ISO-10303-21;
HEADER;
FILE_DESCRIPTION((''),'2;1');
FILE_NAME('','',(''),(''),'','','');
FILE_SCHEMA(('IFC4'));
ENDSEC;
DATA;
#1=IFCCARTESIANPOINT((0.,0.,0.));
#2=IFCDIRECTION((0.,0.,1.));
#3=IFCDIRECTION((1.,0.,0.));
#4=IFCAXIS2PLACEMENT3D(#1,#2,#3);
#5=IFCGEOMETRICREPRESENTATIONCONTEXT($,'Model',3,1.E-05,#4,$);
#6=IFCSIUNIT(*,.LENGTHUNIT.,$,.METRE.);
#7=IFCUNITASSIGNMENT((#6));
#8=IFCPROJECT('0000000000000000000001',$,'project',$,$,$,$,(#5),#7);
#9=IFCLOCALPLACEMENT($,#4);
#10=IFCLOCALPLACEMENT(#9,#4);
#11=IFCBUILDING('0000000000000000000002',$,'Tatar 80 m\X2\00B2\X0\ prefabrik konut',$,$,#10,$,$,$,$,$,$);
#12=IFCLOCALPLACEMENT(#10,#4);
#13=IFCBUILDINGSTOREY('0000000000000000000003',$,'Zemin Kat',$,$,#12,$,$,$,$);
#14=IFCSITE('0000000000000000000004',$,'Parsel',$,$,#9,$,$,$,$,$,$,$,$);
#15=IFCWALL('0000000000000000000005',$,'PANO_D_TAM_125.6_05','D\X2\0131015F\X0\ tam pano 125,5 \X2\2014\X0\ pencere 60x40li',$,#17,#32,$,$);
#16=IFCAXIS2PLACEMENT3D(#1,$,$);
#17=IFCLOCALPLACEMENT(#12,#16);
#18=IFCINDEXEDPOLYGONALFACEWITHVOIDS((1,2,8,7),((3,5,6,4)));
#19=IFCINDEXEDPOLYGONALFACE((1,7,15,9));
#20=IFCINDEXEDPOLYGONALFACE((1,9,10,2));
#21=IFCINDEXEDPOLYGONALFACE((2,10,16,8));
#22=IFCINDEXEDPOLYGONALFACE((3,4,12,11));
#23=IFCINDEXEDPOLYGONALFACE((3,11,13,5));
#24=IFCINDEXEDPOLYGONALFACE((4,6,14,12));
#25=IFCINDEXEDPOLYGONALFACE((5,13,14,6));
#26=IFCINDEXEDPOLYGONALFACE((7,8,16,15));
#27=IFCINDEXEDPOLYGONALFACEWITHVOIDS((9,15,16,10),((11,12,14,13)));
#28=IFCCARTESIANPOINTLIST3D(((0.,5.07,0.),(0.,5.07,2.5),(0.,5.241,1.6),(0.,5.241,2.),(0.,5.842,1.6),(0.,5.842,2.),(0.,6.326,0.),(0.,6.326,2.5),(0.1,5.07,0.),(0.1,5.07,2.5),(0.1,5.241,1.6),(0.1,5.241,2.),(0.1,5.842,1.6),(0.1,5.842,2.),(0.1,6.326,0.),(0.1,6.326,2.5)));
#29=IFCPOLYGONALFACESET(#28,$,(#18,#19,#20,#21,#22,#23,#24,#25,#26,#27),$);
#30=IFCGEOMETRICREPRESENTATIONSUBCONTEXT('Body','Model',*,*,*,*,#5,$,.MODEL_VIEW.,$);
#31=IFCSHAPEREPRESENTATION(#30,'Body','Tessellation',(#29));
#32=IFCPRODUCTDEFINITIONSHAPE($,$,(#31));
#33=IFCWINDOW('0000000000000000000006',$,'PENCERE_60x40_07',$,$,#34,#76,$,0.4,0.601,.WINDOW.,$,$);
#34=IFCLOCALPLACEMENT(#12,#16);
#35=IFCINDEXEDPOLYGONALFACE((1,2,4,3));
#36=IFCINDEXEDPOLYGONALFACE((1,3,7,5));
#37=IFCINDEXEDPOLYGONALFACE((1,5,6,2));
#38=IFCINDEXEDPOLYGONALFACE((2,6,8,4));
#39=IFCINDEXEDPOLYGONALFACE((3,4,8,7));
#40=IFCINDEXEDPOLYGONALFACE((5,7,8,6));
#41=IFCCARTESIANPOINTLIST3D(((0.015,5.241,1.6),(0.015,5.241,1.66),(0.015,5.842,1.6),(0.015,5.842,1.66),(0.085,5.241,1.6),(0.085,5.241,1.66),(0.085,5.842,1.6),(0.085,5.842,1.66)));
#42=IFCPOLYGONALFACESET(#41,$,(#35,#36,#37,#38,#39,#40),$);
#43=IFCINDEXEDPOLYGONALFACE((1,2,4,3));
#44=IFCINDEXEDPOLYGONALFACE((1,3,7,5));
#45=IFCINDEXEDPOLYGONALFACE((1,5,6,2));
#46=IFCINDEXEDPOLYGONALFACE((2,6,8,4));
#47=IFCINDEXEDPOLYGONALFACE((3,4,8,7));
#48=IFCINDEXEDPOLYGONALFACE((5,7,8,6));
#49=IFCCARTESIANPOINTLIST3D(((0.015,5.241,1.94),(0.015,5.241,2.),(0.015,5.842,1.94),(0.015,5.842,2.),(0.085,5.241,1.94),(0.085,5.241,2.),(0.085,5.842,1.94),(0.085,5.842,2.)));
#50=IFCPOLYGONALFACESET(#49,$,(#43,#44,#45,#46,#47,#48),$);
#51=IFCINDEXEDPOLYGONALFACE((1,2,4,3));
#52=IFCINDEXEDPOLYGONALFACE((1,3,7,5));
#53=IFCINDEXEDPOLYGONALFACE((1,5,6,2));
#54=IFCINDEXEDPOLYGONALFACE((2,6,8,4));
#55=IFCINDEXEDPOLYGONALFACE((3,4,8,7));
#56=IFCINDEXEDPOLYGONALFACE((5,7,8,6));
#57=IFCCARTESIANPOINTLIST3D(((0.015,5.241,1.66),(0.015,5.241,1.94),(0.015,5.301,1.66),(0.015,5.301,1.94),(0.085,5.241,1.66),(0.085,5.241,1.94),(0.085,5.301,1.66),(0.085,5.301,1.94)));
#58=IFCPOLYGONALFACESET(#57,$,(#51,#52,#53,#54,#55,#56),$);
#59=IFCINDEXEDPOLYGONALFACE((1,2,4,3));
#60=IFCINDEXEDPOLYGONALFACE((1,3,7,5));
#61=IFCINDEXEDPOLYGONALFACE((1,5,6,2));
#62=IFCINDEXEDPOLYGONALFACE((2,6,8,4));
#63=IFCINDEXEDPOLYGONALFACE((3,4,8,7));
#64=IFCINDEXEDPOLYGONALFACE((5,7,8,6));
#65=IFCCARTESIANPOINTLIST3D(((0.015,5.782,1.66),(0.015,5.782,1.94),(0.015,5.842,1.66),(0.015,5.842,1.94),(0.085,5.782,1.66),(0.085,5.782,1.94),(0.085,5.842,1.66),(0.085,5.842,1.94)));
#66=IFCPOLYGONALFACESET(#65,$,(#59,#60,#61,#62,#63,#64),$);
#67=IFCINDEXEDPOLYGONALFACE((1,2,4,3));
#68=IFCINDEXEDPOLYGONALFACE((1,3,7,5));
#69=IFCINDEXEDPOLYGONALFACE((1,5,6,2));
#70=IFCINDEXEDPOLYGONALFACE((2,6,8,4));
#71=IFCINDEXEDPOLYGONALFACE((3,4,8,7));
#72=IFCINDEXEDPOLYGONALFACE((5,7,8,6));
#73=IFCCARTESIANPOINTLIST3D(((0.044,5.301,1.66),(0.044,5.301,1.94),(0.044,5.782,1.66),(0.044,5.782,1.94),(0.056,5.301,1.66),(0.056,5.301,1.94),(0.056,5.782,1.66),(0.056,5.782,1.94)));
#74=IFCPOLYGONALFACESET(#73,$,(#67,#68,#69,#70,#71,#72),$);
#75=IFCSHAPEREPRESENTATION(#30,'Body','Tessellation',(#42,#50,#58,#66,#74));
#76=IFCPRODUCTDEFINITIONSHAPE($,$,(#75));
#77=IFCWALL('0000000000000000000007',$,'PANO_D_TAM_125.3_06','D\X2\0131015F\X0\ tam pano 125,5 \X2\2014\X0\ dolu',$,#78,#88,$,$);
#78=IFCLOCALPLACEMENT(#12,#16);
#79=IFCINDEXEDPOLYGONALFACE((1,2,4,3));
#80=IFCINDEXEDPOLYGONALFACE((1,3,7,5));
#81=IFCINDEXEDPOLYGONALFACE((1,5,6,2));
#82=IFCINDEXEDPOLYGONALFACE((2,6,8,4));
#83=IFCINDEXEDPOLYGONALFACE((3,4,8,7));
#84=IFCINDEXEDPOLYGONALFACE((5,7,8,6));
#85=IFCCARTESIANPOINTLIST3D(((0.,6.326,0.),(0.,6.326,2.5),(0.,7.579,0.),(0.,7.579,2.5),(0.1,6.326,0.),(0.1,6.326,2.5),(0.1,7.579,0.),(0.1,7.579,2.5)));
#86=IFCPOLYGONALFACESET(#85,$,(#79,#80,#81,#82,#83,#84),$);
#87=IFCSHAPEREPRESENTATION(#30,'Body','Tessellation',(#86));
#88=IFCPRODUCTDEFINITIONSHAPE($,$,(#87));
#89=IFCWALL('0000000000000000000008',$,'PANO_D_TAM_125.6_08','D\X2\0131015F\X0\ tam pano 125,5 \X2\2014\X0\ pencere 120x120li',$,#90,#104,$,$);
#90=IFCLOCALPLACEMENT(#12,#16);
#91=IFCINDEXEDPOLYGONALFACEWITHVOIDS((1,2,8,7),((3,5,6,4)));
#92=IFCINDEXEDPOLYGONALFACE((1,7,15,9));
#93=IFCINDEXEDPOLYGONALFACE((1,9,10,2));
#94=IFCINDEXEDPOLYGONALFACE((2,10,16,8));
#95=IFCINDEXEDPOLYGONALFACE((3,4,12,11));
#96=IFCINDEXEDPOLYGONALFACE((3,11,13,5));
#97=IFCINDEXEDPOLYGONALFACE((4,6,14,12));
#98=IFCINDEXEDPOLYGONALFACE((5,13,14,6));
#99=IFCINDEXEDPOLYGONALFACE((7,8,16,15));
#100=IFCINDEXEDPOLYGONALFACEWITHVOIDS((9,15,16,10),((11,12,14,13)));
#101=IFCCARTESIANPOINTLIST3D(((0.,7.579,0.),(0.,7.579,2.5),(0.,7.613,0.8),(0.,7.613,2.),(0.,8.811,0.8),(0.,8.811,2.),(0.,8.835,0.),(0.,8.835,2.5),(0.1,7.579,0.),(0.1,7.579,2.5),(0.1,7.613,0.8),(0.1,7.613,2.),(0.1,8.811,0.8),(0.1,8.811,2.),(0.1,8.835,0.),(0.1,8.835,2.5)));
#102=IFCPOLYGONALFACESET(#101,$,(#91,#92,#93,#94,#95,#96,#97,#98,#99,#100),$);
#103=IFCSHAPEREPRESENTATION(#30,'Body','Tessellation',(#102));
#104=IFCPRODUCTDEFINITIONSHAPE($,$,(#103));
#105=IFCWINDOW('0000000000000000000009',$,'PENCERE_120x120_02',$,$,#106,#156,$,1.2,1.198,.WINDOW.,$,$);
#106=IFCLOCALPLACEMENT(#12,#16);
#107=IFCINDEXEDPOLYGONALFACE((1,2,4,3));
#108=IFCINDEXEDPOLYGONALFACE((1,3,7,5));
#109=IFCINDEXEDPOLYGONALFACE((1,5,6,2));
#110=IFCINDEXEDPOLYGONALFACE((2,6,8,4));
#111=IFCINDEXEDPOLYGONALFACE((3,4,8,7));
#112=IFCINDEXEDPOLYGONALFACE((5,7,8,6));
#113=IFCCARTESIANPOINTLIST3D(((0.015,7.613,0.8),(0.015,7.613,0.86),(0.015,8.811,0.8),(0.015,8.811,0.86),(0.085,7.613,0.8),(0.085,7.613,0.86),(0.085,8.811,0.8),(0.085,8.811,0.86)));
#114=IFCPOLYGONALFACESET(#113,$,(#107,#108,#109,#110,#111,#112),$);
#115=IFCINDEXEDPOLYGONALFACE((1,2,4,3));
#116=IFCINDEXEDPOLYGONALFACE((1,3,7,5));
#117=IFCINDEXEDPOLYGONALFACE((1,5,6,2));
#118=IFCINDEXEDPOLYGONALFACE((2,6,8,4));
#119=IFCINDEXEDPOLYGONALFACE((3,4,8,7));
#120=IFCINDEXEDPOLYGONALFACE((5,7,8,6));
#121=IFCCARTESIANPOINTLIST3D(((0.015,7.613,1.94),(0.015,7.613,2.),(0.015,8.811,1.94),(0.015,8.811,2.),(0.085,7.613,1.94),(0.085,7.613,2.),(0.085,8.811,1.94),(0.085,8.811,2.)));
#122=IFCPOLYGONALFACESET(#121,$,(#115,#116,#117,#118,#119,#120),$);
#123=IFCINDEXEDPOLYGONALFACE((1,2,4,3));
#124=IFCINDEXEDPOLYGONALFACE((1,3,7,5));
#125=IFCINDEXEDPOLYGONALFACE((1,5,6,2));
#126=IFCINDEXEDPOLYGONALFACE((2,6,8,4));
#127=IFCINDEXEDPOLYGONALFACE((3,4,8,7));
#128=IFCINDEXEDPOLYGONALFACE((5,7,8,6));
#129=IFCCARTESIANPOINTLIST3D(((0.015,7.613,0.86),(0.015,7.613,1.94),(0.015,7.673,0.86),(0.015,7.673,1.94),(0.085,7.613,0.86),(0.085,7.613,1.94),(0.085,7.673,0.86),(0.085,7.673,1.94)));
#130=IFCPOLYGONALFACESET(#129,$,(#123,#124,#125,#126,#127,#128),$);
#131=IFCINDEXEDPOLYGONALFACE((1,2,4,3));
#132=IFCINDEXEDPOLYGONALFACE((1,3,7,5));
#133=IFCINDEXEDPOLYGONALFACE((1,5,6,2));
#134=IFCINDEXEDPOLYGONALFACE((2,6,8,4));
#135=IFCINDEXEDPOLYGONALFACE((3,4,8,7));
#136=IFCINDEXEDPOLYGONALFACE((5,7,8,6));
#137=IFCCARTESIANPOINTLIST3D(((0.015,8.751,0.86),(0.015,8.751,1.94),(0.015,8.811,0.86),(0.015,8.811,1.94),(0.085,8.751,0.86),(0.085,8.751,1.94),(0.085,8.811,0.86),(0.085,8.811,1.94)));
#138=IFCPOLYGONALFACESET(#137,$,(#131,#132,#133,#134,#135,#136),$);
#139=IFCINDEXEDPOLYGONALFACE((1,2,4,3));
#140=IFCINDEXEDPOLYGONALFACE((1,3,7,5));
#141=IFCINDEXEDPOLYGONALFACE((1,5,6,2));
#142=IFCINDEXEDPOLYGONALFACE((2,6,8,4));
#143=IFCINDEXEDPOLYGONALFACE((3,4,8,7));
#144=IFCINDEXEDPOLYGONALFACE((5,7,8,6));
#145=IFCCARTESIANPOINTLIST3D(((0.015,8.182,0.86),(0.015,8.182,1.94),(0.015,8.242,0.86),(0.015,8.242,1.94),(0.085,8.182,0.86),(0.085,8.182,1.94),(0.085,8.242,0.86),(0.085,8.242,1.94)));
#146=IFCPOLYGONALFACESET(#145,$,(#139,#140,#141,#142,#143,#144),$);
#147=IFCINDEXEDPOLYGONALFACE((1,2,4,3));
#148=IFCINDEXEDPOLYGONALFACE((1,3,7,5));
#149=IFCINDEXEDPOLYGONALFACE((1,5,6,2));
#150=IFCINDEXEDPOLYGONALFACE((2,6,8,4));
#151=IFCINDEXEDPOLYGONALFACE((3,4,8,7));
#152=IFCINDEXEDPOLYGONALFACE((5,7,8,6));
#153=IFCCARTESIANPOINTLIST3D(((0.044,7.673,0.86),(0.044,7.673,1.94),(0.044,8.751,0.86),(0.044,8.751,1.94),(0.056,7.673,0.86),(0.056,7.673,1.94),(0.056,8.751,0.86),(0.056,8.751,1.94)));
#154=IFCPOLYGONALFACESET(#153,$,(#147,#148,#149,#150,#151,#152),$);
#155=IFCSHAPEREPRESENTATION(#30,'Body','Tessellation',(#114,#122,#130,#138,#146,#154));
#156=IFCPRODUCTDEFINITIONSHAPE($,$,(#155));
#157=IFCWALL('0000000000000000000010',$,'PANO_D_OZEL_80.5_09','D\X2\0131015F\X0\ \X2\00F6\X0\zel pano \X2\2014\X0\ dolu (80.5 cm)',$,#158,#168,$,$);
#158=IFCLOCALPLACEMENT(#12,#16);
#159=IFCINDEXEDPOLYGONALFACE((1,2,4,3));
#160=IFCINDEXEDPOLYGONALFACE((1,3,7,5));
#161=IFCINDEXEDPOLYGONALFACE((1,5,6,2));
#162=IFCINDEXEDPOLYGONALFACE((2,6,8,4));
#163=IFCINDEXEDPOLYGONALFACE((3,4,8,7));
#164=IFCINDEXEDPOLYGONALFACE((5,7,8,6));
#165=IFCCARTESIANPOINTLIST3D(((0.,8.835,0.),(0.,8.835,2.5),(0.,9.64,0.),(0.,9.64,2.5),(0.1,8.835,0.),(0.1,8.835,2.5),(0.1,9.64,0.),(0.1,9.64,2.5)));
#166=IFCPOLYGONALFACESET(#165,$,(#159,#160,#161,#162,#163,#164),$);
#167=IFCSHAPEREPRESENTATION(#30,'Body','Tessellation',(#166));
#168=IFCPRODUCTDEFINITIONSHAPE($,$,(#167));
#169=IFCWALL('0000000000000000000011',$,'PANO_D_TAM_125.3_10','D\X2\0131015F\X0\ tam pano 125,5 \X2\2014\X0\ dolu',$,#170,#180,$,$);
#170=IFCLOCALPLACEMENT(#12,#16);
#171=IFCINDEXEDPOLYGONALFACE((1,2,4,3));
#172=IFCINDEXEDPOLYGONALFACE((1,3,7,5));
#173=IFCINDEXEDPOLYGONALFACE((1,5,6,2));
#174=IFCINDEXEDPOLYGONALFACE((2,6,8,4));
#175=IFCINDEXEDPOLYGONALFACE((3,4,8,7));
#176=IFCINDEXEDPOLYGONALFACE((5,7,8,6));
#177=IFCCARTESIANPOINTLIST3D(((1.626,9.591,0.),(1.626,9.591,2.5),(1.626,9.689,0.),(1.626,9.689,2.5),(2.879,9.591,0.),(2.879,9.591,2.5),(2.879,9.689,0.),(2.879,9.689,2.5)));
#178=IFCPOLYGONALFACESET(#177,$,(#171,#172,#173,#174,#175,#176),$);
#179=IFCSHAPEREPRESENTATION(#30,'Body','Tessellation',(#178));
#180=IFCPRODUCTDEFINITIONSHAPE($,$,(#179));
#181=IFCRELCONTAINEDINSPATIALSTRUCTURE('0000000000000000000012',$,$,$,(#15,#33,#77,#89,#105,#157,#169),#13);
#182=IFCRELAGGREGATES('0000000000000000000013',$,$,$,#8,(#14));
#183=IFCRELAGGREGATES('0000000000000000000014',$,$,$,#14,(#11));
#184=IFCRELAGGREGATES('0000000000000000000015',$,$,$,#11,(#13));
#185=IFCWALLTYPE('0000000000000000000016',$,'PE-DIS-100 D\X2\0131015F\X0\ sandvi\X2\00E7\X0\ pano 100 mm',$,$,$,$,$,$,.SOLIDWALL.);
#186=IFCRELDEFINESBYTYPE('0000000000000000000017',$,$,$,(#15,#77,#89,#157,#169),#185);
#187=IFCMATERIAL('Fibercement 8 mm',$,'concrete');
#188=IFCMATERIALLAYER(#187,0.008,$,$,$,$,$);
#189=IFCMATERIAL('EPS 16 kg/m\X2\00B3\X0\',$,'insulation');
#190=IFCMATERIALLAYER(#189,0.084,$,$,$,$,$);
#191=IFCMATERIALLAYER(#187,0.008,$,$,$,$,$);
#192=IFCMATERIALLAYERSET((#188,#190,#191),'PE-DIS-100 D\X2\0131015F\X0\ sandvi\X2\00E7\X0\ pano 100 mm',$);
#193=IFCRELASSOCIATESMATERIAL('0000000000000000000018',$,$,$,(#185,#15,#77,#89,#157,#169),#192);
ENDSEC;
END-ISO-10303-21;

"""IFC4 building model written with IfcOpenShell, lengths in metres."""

from ifc_helpers import new_model, si_unit, frame, origin_with_axes, place, context, subcontext, project, spatial, line, indexed_curve, outline, extrude, material, layer, layer_set, layer_usage, type_object, element, fill, save


model = new_model("IFC4")

# Units and contexts
model_context = context("Model", 3, precision=1e-05, world=origin_with_axes())
body_context = subcontext(model_context, "Body", "Model", "MODEL_VIEW")
ifc_project = project(units=[si_unit("LENGTHUNIT", "METRE")], contexts=[model_context])

# Site, building, storey
site_placement = place(None, origin_with_axes())
site = spatial("IfcSite", under=ifc_project, at=site_placement, Name="Parsel")
building_placement = place(site_placement, origin_with_axes())
building = spatial("IfcBuilding", under=site, at=building_placement, Name="Tatar 80 m² prefabrik konut")
storey_placement = place(building_placement, origin_with_axes())
storey = spatial("IfcBuildingStorey", under=building, at=storey_placement, Name="Zemin Kat")

# Wall, opening, window
ifc_material_1 = material(Name="Fibercement 8 mm", Category="concrete")
ifc_layer_1 = layer(ifc_material_1, 0.008)
ifc_material_2 = material(Name="EPS 16 kg/m³", Category="insulation")
ifc_layer_2 = layer(ifc_material_2, 0.084)
ifc_layer_3 = layer(ifc_material_1, 0.008)
ifc_layer_set_1 = layer_set([ifc_layer_1, ifc_layer_2, ifc_layer_3], Name="PE-DIS-100 Dış sandviç pano 100 mm")
ifc_layer_usage_1 = layer_usage(ifc_layer_set_1, "AXIS2", "POSITIVE", 0.0)
wall_type_1 = type_object("IfcWallType", Name="PE-DIS-100 Dış sandviç pano 100 mm", PredefinedType="SOLIDWALL", material=ifc_layer_set_1)
wall_1_placement = place(storey_placement, frame((0.1, 5.07, 0.0), z_axis=(0.0, 0.0, 1.0), x_axis=(0.0, 1.0, 0.0)))
wall_1 = element("IfcWall", 1, at=wall_1_placement, inside=storey, type_object=wall_type_1, material=ifc_layer_usage_1, Name="PANO_D_TAM_125.6_05", Description="Dış tam pano 125,5 — pencere 60x40li", context=body_context, shape_type="SweptSolid", body=[
    extrude(outline(indexed_curve([(0.0, 0.0), (1.256, 0.0), (1.256, 0.1), (0.0, 0.1)], segments=[line(1, 2, 3, 4, 1)])), origin_with_axes(), (0.0, 0.0, 1.0), 2.5),
])
opening_1_placement = place(wall_1_placement, origin_with_axes())
opening_1 = element("IfcOpeningElement", 2, at=opening_1_placement, cuts=wall_1, PredefinedType="OPENING", context=body_context, shape_type="SweptSolid", body=[
    extrude(outline(indexed_curve([(0.0, 0.0), (0.601, 0.0), (0.601, 0.14), (0.0, 0.14)], segments=[line(1, 2, 3, 4, 1)])), frame((0.171, -0.02, 1.6), z_axis=(0.0, 0.0, 1.0), x_axis=(1.0, 0.0, 0.0)), (0.0, 0.0, 1.0), 0.4),
])
window_1_placement = place(storey_placement, frame((0.1, 5.07, 0.0), z_axis=(0.0, 0.0, 1.0), x_axis=(0.0, 1.0, 0.0)))
window_1 = element("IfcWindow", 3, at=window_1_placement, inside=storey, Name="PENCERE_60x40_07", OverallHeight=0.4, OverallWidth=0.601, PredefinedType="WINDOW", context=body_context, shape_type="SweptSolid", body=[
    extrude(outline(indexed_curve([(0.0, 0.0), (0.601, 0.0), (0.601, 0.07), (0.0, 0.07)], segments=[line(1, 2, 3, 4, 1)])), frame((0.171, 0.015, 1.6), z_axis=(0.0, 0.0, 1.0), x_axis=(1.0, 0.0, 0.0)), (0.0, 0.0, 1.0), 0.06),
    extrude(outline(indexed_curve([(0.0, 0.0), (0.601, 0.0), (0.601, 0.07), (0.0, 0.07)], segments=[line(1, 2, 3, 4, 1)])), frame((0.171, 0.015, 1.94), z_axis=(0.0, 0.0, 1.0), x_axis=(1.0, 0.0, 0.0)), (0.0, 0.0, 1.0), 0.06),
    extrude(outline(indexed_curve([(0.0, 0.0), (0.06, 0.0), (0.06, 0.07), (0.0, 0.07)], segments=[line(1, 2, 3, 4, 1)])), frame((0.171, 0.015, 1.66), z_axis=(0.0, 0.0, 1.0), x_axis=(1.0, 0.0, 0.0)), (0.0, 0.0, 1.0), 0.28),
    extrude(outline(indexed_curve([(0.0, 0.0), (0.06, 0.0), (0.06, 0.07), (0.0, 0.07)], segments=[line(1, 2, 3, 4, 1)])), frame((0.712, 0.015, 1.66), z_axis=(0.0, 0.0, 1.0), x_axis=(1.0, 0.0, 0.0)), (0.0, 0.0, 1.0), 0.28),
    extrude(outline(indexed_curve([(0.0, 0.0), (0.481, 0.0), (0.481, 0.012), (0.0, 0.012)], segments=[line(1, 2, 3, 4, 1)])), frame((0.231, 0.044, 1.66), z_axis=(0.0, 0.0, 1.0), x_axis=(1.0, 0.0, 0.0)), (0.0, 0.0, 1.0), 0.28),
])
fill(opening_1, window_1)

# Wall
ifc_layer_usage_2 = layer_usage(ifc_layer_set_1, "AXIS2", "POSITIVE", 0.0)
wall_2_placement = place(storey_placement, frame((0.1, 6.326, 0.0), z_axis=(0.0, 0.0, 1.0), x_axis=(0.0, 1.0, 0.0)))
element("IfcWall", 4, at=wall_2_placement, inside=storey, type_object=wall_type_1, material=ifc_layer_usage_2, Name="PANO_D_TAM_125.3_06", Description="Dış tam pano 125,5 — dolu", context=body_context, shape_type="SweptSolid", body=[
    extrude(outline(indexed_curve([(0.0, 0.0), (1.253, 0.0), (1.253, 0.1), (0.0, 0.1)], segments=[line(1, 2, 3, 4, 1)])), origin_with_axes(), (0.0, 0.0, 1.0), 2.5),
])

# Wall, opening, window
ifc_layer_usage_3 = layer_usage(ifc_layer_set_1, "AXIS2", "POSITIVE", 0.0)
wall_3_placement = place(storey_placement, frame((0.1, 7.579, 0.0), z_axis=(0.0, 0.0, 1.0), x_axis=(0.0, 1.0, 0.0)))
wall_3 = element("IfcWall", 5, at=wall_3_placement, inside=storey, type_object=wall_type_1, material=ifc_layer_usage_3, Name="PANO_D_TAM_125.6_08", Description="Dış tam pano 125,5 — pencere 120x120li", context=body_context, shape_type="SweptSolid", body=[
    extrude(outline(indexed_curve([(0.0, 0.0), (1.256, 0.0), (1.256, 0.1), (0.0, 0.1)], segments=[line(1, 2, 3, 4, 1)])), origin_with_axes(), (0.0, 0.0, 1.0), 2.5),
])
opening_2_placement = place(wall_3_placement, origin_with_axes())
opening_2 = element("IfcOpeningElement", 6, at=opening_2_placement, cuts=wall_3, PredefinedType="OPENING", context=body_context, shape_type="SweptSolid", body=[
    extrude(outline(indexed_curve([(0.0, 0.0), (1.198, 0.0), (1.198, 0.14), (0.0, 0.14)], segments=[line(1, 2, 3, 4, 1)])), frame((0.034, -0.02, 0.8), z_axis=(0.0, 0.0, 1.0), x_axis=(1.0, 0.0, 0.0)), (0.0, 0.0, 1.0), 1.2),
])
window_2_placement = place(storey_placement, frame((0.1, 7.579, 0.0), z_axis=(0.0, 0.0, 1.0), x_axis=(0.0, 1.0, 0.0)))
window_2 = element("IfcWindow", 7, at=window_2_placement, inside=storey, Name="PENCERE_120x120_02", OverallHeight=1.2, OverallWidth=1.198, PredefinedType="WINDOW", context=body_context, shape_type="SweptSolid", body=[
    extrude(outline(indexed_curve([(0.0, 0.0), (1.198, 0.0), (1.198, 0.07), (0.0, 0.07)], segments=[line(1, 2, 3, 4, 1)])), frame((0.034, 0.015, 0.8), z_axis=(0.0, 0.0, 1.0), x_axis=(1.0, 0.0, 0.0)), (0.0, 0.0, 1.0), 0.06),
    extrude(outline(indexed_curve([(0.0, 0.0), (1.198, 0.0), (1.198, 0.07), (0.0, 0.07)], segments=[line(1, 2, 3, 4, 1)])), frame((0.034, 0.015, 1.94), z_axis=(0.0, 0.0, 1.0), x_axis=(1.0, 0.0, 0.0)), (0.0, 0.0, 1.0), 0.06),
    extrude(outline(indexed_curve([(0.0, 0.0), (0.06, 0.0), (0.06, 0.07), (0.0, 0.07)], segments=[line(1, 2, 3, 4, 1)])), frame((0.034, 0.015, 0.86), z_axis=(0.0, 0.0, 1.0), x_axis=(1.0, 0.0, 0.0)), (0.0, 0.0, 1.0), 1.08),
    extrude(outline(indexed_curve([(0.0, 0.0), (0.06, 0.0), (0.06, 0.07), (0.0, 0.07)], segments=[line(1, 2, 3, 4, 1)])), frame((1.172, 0.015, 0.86), z_axis=(0.0, 0.0, 1.0), x_axis=(1.0, 0.0, 0.0)), (0.0, 0.0, 1.0), 1.08),
    extrude(outline(indexed_curve([(0.0, 0.0), (0.06, 0.0), (0.06, 0.07), (0.0, 0.07)], segments=[line(1, 2, 3, 4, 1)])), frame((0.603, 0.015, 0.86), z_axis=(0.0, 0.0, 1.0), x_axis=(1.0, 0.0, 0.0)), (0.0, 0.0, 1.0), 1.08),
    extrude(outline(indexed_curve([(0.0, 0.0), (1.078, 0.0), (1.078, 0.012), (0.0, 0.012)], segments=[line(1, 2, 3, 4, 1)])), frame((0.094, 0.044, 0.86), z_axis=(0.0, 0.0, 1.0), x_axis=(1.0, 0.0, 0.0)), (0.0, 0.0, 1.0), 1.08),
])
fill(opening_2, window_2)

# Walls
ifc_layer_usage_4 = layer_usage(ifc_layer_set_1, "AXIS2", "POSITIVE", 0.0)
wall_4_placement = place(storey_placement, frame((0.1, 8.835, 0.0), z_axis=(0.0, 0.0, 1.0), x_axis=(0.0, 1.0, 0.0)))
element("IfcWall", 8, at=wall_4_placement, inside=storey, type_object=wall_type_1, material=ifc_layer_usage_4, Name="PANO_D_OZEL_80.5_09", Description="Dış özel pano — dolu (80.5 cm)", context=body_context, shape_type="SweptSolid", body=[
    extrude(outline(indexed_curve([(0.0, 0.0), (0.805, 0.0), (0.805, 0.1), (0.0, 0.1)], segments=[line(1, 2, 3, 4, 1)])), origin_with_axes(), (0.0, 0.0, 1.0), 2.5),
])
ifc_layer_usage_5 = layer_usage(ifc_layer_set_1, "AXIS2", "POSITIVE", 0.0)
wall_5_placement = place(storey_placement, frame((1.626, 9.591, 0.0), z_axis=(0.0, 0.0, 1.0), x_axis=(1.0, 0.0, 0.0)))
element("IfcWall", 9, at=wall_5_placement, inside=storey, type_object=wall_type_1, material=ifc_layer_usage_5, Name="PANO_D_TAM_125.3_10", Description="Dış tam pano 125,5 — dolu", context=body_context, shape_type="SweptSolid", body=[
    extrude(outline(indexed_curve([(0.0, 0.0), (1.253, 0.0), (1.253, 0.098), (0.0, 0.098)], segments=[line(1, 2, 3, 4, 1)])), origin_with_axes(), (0.0, 0.0, 1.0), 2.5),
])

save(model, "model.ifc")
